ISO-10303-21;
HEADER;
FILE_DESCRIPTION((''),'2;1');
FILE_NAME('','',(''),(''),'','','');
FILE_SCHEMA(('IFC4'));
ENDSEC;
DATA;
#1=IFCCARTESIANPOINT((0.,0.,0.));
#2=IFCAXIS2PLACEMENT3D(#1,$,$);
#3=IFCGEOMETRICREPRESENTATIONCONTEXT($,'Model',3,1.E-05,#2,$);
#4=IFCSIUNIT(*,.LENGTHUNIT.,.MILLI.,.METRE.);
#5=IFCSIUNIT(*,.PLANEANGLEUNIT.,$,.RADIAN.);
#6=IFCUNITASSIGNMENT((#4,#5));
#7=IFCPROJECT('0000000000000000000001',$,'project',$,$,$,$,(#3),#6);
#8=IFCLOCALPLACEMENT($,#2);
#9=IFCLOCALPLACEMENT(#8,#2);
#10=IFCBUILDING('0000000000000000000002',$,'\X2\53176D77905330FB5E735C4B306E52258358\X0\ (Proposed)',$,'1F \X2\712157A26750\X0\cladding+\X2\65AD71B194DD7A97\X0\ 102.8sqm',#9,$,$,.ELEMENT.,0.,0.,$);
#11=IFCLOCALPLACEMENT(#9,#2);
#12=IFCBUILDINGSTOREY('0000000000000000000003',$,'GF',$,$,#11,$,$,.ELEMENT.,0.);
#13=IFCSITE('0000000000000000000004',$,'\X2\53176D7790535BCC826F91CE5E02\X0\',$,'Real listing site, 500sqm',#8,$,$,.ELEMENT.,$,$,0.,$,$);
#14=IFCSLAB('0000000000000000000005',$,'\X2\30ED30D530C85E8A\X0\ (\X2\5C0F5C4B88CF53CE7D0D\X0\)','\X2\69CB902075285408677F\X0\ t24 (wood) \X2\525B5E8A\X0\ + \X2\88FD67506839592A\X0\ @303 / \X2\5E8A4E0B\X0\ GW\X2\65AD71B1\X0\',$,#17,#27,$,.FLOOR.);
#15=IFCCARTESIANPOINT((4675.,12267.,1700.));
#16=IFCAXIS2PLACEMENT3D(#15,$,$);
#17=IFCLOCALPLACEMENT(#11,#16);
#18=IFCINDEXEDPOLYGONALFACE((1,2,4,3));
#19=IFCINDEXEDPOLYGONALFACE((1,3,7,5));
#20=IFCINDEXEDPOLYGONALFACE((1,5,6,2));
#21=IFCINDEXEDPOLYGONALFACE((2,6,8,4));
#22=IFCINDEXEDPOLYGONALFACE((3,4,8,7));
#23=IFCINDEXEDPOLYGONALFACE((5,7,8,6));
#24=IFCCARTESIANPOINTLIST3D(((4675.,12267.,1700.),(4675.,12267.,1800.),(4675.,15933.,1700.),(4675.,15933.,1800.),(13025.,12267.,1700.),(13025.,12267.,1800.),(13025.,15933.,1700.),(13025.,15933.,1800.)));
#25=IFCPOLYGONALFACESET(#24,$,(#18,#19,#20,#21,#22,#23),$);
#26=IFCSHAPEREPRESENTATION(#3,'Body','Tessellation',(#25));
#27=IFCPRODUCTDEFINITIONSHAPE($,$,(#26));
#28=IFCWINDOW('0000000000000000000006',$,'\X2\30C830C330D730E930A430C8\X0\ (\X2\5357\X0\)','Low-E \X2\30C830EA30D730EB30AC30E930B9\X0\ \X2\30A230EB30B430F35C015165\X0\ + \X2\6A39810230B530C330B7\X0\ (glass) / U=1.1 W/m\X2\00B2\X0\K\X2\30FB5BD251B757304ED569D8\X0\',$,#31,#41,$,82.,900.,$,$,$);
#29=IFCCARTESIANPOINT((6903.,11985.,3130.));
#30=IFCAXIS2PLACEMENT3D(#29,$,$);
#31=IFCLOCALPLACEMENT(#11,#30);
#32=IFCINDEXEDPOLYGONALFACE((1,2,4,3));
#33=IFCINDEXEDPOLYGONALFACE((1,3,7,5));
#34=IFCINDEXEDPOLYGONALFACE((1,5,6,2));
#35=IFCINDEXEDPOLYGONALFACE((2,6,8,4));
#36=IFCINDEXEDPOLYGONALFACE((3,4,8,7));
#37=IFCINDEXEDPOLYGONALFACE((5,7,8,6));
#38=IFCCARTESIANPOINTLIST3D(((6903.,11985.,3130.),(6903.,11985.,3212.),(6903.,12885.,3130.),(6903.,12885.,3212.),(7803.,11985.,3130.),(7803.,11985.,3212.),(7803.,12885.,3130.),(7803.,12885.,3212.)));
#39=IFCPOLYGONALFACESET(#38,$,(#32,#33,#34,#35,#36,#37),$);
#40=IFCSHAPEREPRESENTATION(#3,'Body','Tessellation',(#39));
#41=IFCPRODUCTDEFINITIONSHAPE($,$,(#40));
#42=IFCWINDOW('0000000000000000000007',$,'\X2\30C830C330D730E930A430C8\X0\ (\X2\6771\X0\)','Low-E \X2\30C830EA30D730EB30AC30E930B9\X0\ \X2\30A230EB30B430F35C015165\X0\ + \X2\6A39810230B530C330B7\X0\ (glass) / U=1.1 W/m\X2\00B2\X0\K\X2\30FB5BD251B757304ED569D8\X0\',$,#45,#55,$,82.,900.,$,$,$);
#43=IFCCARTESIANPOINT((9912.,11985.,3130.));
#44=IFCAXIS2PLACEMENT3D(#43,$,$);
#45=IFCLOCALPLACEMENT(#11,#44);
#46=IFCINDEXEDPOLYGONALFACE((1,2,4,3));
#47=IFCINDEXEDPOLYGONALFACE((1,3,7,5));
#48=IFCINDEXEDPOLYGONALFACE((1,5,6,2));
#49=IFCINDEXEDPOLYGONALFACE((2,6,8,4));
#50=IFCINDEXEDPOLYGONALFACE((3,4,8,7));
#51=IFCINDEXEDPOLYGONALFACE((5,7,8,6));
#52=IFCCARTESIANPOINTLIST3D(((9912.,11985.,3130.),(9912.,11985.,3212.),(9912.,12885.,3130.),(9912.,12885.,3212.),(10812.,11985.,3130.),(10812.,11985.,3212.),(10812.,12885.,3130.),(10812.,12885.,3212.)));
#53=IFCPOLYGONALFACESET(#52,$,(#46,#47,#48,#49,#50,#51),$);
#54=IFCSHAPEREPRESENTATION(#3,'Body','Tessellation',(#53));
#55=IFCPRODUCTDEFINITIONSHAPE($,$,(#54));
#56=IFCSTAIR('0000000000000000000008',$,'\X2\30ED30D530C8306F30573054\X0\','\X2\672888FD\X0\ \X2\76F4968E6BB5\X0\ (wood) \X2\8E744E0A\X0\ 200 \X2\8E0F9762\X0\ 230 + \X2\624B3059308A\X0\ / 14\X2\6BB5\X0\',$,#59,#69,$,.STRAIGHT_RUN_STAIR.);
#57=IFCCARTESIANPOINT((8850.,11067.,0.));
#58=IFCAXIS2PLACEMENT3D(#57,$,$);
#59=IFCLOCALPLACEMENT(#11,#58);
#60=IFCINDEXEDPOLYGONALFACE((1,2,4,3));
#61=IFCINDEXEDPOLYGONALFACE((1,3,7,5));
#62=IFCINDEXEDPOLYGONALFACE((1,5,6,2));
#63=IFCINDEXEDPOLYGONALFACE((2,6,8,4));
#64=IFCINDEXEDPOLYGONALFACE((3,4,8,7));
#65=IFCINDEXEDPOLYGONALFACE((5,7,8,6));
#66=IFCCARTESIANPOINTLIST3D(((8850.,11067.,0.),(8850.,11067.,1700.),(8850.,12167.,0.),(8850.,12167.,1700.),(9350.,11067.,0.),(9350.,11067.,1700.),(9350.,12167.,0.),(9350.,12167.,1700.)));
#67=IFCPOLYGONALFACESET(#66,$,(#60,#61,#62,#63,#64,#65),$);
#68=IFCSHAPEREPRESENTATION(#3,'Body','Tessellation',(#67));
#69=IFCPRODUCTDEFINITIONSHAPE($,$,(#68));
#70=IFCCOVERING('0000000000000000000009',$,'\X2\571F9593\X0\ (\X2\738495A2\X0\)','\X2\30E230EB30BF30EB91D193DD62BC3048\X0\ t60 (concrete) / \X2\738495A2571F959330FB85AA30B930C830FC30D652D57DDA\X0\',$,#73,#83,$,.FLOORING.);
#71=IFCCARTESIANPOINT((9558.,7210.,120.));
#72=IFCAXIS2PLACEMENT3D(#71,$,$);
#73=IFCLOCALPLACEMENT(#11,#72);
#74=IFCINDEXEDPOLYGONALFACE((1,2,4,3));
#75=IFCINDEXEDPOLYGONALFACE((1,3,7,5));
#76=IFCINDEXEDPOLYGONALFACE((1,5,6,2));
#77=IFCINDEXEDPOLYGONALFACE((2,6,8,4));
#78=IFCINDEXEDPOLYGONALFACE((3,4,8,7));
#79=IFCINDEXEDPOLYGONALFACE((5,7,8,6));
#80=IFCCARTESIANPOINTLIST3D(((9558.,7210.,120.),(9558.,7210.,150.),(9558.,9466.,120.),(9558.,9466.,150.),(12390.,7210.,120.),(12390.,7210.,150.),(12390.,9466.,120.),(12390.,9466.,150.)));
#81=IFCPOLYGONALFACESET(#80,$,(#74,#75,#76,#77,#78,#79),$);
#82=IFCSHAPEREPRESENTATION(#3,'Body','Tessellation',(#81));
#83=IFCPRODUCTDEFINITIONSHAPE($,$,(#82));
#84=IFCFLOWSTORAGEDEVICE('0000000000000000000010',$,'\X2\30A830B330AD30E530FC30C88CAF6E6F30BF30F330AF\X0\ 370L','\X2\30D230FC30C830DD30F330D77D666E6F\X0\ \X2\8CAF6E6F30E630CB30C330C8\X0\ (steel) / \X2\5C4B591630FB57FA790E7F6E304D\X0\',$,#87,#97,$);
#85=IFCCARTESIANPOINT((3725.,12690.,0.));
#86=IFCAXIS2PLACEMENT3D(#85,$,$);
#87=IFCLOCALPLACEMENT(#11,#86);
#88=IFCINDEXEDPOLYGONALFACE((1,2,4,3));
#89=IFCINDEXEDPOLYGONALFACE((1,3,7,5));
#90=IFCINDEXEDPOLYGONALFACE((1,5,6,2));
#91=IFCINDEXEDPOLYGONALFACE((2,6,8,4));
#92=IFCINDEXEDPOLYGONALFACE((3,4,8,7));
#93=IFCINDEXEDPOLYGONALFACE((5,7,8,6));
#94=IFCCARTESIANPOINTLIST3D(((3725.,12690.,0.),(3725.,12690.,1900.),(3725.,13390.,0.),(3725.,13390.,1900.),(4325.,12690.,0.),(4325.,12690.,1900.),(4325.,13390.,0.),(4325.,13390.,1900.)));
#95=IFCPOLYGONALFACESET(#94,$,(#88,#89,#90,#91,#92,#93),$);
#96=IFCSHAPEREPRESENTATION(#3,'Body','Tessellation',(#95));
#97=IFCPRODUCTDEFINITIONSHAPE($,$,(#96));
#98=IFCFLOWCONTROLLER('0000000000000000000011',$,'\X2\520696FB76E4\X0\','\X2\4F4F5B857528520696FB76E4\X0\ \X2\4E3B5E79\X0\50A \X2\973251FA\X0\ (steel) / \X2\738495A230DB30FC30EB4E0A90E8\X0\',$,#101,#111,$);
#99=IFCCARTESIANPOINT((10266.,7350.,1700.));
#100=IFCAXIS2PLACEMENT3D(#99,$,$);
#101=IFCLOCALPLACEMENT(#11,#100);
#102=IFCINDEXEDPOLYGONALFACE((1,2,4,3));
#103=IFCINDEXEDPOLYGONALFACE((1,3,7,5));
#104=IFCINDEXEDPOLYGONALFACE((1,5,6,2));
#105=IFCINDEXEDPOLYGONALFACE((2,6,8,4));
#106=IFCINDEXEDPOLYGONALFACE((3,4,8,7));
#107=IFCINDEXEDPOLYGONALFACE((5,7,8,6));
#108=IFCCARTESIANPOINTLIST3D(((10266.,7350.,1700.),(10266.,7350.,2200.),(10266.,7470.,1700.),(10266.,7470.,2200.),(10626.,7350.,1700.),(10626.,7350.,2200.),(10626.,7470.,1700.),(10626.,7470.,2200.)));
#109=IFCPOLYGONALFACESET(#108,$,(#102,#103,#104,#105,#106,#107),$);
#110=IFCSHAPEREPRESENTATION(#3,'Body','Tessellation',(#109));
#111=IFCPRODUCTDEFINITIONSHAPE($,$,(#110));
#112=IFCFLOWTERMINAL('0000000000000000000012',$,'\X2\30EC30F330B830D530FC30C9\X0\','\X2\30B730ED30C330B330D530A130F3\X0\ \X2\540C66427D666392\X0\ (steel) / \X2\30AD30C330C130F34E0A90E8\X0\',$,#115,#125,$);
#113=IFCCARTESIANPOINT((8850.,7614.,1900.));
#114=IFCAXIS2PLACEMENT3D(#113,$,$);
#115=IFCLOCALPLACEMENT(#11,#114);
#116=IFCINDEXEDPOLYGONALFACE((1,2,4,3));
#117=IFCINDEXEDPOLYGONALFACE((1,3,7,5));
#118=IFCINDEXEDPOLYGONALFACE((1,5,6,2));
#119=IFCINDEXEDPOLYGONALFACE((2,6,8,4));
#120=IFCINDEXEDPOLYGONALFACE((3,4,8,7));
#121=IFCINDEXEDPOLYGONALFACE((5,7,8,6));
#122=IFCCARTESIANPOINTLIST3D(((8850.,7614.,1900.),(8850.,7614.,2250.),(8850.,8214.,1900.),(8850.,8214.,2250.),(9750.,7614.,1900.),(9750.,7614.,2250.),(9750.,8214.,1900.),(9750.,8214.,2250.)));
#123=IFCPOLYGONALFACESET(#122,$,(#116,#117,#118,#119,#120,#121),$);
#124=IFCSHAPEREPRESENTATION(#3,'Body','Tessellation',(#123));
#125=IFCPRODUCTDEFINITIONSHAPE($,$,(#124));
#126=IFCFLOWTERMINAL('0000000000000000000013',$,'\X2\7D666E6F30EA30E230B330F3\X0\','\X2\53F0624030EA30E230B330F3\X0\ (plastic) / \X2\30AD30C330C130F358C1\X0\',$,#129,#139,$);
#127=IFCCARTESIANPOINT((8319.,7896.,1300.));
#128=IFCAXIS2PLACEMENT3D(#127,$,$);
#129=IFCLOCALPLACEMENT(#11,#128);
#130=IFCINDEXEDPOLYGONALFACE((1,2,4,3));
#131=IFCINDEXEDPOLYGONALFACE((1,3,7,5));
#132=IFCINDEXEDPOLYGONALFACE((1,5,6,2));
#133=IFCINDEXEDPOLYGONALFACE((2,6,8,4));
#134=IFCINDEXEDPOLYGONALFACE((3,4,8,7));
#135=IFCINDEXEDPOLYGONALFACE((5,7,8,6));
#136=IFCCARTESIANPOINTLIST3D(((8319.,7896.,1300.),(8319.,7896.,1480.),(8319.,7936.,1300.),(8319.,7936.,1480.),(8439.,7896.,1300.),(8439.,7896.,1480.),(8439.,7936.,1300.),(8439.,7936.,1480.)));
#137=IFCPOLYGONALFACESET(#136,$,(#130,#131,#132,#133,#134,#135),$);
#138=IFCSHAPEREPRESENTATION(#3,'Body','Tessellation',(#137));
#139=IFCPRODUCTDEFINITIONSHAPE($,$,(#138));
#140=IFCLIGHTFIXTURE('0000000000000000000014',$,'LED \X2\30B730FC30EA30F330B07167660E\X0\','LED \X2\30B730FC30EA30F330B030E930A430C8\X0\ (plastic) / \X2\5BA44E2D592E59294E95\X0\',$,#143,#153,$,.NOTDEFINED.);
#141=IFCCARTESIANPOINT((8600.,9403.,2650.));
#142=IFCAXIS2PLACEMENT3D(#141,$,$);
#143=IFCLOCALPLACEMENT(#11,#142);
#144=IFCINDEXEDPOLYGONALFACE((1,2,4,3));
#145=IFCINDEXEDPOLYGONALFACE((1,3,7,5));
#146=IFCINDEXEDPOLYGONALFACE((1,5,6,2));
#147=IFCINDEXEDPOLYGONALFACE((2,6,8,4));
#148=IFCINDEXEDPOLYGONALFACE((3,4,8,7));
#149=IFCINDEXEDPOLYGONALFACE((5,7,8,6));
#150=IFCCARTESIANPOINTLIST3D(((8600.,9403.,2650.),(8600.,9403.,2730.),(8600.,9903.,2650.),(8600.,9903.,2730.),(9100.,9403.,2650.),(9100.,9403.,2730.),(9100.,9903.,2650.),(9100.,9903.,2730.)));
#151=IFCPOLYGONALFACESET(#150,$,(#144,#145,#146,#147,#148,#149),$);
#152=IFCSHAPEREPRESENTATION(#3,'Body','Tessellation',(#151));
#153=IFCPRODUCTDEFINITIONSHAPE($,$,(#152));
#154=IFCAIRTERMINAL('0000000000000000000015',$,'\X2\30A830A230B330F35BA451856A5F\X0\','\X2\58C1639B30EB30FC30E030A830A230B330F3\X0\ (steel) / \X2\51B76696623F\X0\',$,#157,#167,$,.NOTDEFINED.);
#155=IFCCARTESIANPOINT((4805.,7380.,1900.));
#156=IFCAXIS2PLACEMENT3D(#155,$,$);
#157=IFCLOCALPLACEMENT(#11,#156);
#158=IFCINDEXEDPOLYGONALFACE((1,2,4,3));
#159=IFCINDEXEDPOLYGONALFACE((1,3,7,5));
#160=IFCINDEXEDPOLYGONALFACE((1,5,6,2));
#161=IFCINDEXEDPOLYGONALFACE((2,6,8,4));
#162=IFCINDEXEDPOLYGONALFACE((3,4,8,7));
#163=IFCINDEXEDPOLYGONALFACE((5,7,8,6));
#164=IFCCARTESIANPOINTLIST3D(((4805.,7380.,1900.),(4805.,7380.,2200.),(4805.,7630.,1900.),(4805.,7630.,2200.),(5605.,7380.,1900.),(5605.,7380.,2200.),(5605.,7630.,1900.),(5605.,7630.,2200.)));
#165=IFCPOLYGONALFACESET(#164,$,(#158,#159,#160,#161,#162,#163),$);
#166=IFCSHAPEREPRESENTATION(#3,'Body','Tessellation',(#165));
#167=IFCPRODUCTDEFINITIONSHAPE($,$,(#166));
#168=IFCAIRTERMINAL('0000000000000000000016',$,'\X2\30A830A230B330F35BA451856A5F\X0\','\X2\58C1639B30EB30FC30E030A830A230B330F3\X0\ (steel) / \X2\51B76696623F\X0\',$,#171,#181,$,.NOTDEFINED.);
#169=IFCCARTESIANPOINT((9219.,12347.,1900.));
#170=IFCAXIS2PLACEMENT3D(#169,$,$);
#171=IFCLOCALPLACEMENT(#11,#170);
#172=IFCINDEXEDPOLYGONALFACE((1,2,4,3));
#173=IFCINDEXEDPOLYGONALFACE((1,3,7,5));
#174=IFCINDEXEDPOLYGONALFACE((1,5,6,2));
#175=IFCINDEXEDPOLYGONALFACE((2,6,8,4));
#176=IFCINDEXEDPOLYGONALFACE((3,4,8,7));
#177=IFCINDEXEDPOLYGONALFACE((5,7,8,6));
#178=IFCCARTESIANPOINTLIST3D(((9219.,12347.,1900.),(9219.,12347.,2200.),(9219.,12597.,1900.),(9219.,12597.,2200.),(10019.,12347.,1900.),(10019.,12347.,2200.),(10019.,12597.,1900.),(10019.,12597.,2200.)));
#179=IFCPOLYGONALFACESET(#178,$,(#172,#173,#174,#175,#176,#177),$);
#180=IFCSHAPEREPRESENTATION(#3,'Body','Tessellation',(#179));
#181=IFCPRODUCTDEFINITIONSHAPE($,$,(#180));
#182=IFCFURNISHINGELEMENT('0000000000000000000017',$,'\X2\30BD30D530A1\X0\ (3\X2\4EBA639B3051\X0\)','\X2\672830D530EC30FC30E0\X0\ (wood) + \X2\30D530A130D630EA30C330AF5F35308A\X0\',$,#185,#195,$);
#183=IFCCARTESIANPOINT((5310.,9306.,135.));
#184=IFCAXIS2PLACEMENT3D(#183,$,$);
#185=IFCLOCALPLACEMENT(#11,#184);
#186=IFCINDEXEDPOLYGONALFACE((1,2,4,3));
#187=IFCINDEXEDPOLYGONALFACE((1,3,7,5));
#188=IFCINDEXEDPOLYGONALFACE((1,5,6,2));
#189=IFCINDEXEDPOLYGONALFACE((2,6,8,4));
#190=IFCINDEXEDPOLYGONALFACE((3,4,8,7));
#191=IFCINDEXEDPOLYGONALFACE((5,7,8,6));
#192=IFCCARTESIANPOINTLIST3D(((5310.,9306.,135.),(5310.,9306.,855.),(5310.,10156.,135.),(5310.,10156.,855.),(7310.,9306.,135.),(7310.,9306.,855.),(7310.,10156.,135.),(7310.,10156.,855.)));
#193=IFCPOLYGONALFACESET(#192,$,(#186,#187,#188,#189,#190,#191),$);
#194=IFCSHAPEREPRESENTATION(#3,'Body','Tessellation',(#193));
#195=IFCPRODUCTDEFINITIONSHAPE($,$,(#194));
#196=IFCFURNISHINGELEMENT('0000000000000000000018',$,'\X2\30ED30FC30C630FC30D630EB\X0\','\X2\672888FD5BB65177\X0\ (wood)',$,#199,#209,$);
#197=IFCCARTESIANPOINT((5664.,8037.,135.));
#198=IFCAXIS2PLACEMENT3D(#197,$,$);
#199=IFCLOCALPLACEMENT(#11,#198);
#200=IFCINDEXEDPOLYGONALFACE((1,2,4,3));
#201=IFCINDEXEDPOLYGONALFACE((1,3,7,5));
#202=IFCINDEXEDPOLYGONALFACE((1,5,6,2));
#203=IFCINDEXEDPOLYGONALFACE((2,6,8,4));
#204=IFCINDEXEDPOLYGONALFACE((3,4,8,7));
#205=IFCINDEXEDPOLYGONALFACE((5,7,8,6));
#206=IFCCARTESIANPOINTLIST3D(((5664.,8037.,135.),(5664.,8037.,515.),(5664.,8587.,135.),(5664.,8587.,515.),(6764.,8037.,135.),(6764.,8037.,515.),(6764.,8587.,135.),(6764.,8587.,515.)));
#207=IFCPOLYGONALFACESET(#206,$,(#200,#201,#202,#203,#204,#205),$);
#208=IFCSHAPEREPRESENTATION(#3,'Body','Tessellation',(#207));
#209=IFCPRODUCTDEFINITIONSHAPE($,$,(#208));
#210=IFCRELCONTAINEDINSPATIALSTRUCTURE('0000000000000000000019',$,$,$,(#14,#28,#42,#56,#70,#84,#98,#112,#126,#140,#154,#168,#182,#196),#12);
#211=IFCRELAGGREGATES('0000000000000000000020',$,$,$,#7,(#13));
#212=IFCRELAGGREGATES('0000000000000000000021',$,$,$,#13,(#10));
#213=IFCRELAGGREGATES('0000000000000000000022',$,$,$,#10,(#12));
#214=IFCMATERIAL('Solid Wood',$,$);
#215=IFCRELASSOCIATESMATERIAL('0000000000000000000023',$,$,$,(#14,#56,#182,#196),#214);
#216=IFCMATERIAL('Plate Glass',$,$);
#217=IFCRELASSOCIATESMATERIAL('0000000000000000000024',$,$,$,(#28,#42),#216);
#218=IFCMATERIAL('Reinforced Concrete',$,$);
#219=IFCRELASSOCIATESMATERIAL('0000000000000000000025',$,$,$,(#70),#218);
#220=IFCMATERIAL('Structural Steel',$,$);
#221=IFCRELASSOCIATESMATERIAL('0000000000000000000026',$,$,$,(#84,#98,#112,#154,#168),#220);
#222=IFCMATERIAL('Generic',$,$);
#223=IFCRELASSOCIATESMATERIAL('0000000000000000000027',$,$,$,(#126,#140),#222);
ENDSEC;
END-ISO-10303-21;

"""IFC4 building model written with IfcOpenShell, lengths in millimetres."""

from ifc_helpers import new_model, si_unit, frame, frame_2d, origin, place, context, project, spatial, rectangle, extrude, material, element, save


model = new_model("IFC4")

# Units and contexts
model_context = context("Model", 3, precision=1e-05, world=origin())
ifc_project = project(units=[si_unit("LENGTHUNIT", "METRE", prefix="MILLI"), si_unit("PLANEANGLEUNIT", "RADIAN")], contexts=[model_context])

# Site, building, storey
site_placement = place(None, origin())
site = spatial("IfcSite", under=ifc_project, at=site_placement, Name="北海道富良野市", ObjectType="Real listing site, 500sqm", CompositionType="ELEMENT", RefElevation=0.0)
building_placement = place(site_placement, origin())
building = spatial("IfcBuilding", under=site, at=building_placement, Name="北海道・平屋の別荘 (Proposed)", ObjectType="1F 無垢材cladding+断熱铝窗 102.8sqm", CompositionType="ELEMENT", ElevationOfRefHeight=0.0, ElevationOfTerrain=0.0)
storey_placement = place(building_placement, origin())
storey = spatial("IfcBuildingStorey", under=building, at=storey_placement, Name="GF", CompositionType="ELEMENT", Elevation=0.0)

# Shared definitions
ifc_material_1 = material(Name="Solid Wood")

# Slab
slab_placement = place(storey_placement, frame((4675.0, 12267.0, 1700.0)))
element("IfcSlab", 1, at=slab_placement, inside=storey, material=ifc_material_1, Name="ロフト床 (小屋裏収納)", Description="構造用合板 t24 (wood) 剛床 + 製材根太 @303 / 床下 GW断熱", PredefinedType="FLOOR", context=model_context, shape_type="SweptSolid", body=[
    extrude(rectangle(XDim=8350.0, YDim=3666.0, at=frame_2d((4175.0, 1833.0))), frame((4675.0, 12267.0, 1700.0)), (0.0, 0.0, 1.0), 100.0),
])

# Windows
ifc_material_2 = material(Name="Plate Glass")
window_1_placement = place(storey_placement, frame((6903.0, 11985.0, 3130.0)))
element("IfcWindow", 2, at=window_1_placement, inside=storey, material=ifc_material_2, Name="トップライト (南)", Description="Low-E トリプルガラス アルゴン封入 + 樹脂サッシ (glass) / U=1.1 W/m²K・寒冷地仕様", OverallHeight=82.0, OverallWidth=900.0, context=model_context, shape_type="SweptSolid", body=[
    extrude(rectangle(XDim=900.0, YDim=900.0, at=frame_2d((450.0, 450.0))), frame((6903.0, 11985.0, 3130.0)), (0.0, 0.0, 1.0), 82.0),
])
window_2_placement = place(storey_placement, frame((9912.0, 11985.0, 3130.0)))
element("IfcWindow", 3, at=window_2_placement, inside=storey, material=ifc_material_2, Name="トップライト (東)", Description="Low-E トリプルガラス アルゴン封入 + 樹脂サッシ (glass) / U=1.1 W/m²K・寒冷地仕様", OverallHeight=82.0, OverallWidth=900.0, context=model_context, shape_type="SweptSolid", body=[
    extrude(rectangle(XDim=900.0, YDim=900.0, at=frame_2d((450.0, 450.0))), frame((9912.0, 11985.0, 3130.0)), (0.0, 0.0, 1.0), 82.0),
])

# Stair
stair_placement = place(storey_placement, frame((8850.0, 11067.0, 0.0)))
element("IfcStair", 4, at=stair_placement, inside=storey, material=ifc_material_1, Name="ロフトはしご", Description="木製 直階段 (wood) 蹴上 200 踏面 230 + 手すり / 14段", PredefinedType="STRAIGHT_RUN_STAIR", context=model_context, shape_type="SweptSolid", body=[
    extrude(rectangle(XDim=500.0, YDim=1100.0, at=frame_2d((250.0, 550.0))), frame((8850.0, 11067.0, 0.0)), (0.0, 0.0, 1.0), 1700.0),
])

# Covering
ifc_material_3 = material(Name="Reinforced Concrete")
covering_placement = place(storey_placement, frame((9558.0, 7210.0, 120.0)))
element("IfcCovering", 5, at=covering_placement, inside=storey, material=ifc_material_3, Name="土間 (玄関)", Description="モルタル金鏝押え t60 (concrete) / 玄関土間・薪ストーブ動線", PredefinedType="FLOORING", context=model_context, shape_type="SweptSolid", body=[
    extrude(rectangle(XDim=2832.0, YDim=2256.0, at=frame_2d((1416.0, 1128.0))), frame((9558.0, 7210.0, 120.0)), (0.0, 0.0, 1.0), 30.0),
])

# Flow storage device
ifc_material_4 = material(Name="Structural Steel")
flow_storage_device_placement = place(storey_placement, frame((3725.0, 12690.0, 0.0)))
element("IfcFlowStorageDevice", 6, at=flow_storage_device_placement, inside=storey, material=ifc_material_4, Name="エコキュート貯湯タンク 370L", Description="ヒートポンプ給湯 貯湯ユニット (steel) / 屋外・基礎置き", context=model_context, shape_type="SweptSolid", body=[
    extrude(rectangle(XDim=600.0, YDim=700.0, at=frame_2d((300.0, 350.0))), frame((3725.0, 12690.0, 0.0)), (0.0, 0.0, 1.0), 1900.0),
])

# Flow controller
flow_controller_placement = place(storey_placement, frame((10266.0, 7350.0, 1700.0)))
element("IfcFlowController", 7, at=flow_controller_placement, inside=storey, material=ifc_material_4, Name="分電盤", Description="住宅用分電盤 主幹50A 露出 (steel) / 玄関ホール上部", context=model_context, shape_type="SweptSolid", body=[
    extrude(rectangle(XDim=360.0, YDim=120.0, at=frame_2d((180.0, 60.0))), frame((10266.0, 7350.0, 1700.0)), (0.0, 0.0, 1.0), 500.0),
])

# Flow terminals
flow_terminal_1_placement = place(storey_placement, frame((8850.0, 7614.0, 1900.0)))
element("IfcFlowTerminal", 8, at=flow_terminal_1_placement, inside=storey, material=ifc_material_4, Name="レンジフード", Description="シロッコファン 同時給排 (steel) / キッチン上部", context=model_context, shape_type="SweptSolid", body=[
    extrude(rectangle(XDim=900.0, YDim=600.0, at=frame_2d((450.0, 300.0))), frame((8850.0, 7614.0, 1900.0)), (0.0, 0.0, 1.0), 350.0),
])
ifc_material_5 = material(Name="Generic")
flow_terminal_2_placement = place(storey_placement, frame((8319.0, 7896.0, 1300.0)))
element("IfcFlowTerminal", 9, at=flow_terminal_2_placement, inside=storey, material=ifc_material_5, Name="給湯リモコン", Description="台所リモコン (plastic) / キッチン壁", context=model_context, shape_type="SweptSolid", body=[
    extrude(rectangle(XDim=120.0, YDim=40.0, at=frame_2d((60.0, 20.0))), frame((8319.0, 7896.0, 1300.0)), (0.0, 0.0, 1.0), 180.0),
])

# Light fixture
light_fixture_placement = place(storey_placement, frame((8600.0, 9403.0, 2650.0)))
element("IfcLightFixture", 10, at=light_fixture_placement, inside=storey, material=ifc_material_5, Name="LED シーリング照明", Description="LED シーリングライト (plastic) / 室中央天井", PredefinedType="NOTDEFINED", context=model_context, shape_type="SweptSolid", body=[
    extrude(rectangle(XDim=500.0, YDim=500.0, at=frame_2d((250.0, 250.0))), frame((8600.0, 9403.0, 2650.0)), (0.0, 0.0, 1.0), 80.0),
])

# Air terminals
air_terminal_1_placement = place(storey_placement, frame((4805.0, 7380.0, 1900.0)))
element("IfcAirTerminal", 11, at=air_terminal_1_placement, inside=storey, material=ifc_material_4, Name="エアコン室内機", Description="壁掛ルームエアコン (steel) / 冷暖房", PredefinedType="NOTDEFINED", context=model_context, shape_type="SweptSolid", body=[
    extrude(rectangle(XDim=800.0, YDim=250.0, at=frame_2d((400.0, 125.0))), frame((4805.0, 7380.0, 1900.0)), (0.0, 0.0, 1.0), 300.0),
])
air_terminal_2_placement = place(storey_placement, frame((9219.0, 12347.0, 1900.0)))
element("IfcAirTerminal", 12, at=air_terminal_2_placement, inside=storey, material=ifc_material_4, Name="エアコン室内機", Description="壁掛ルームエアコン (steel) / 冷暖房", PredefinedType="NOTDEFINED", context=model_context, shape_type="SweptSolid", body=[
    extrude(rectangle(XDim=800.0, YDim=250.0, at=frame_2d((400.0, 125.0))), frame((9219.0, 12347.0, 1900.0)), (0.0, 0.0, 1.0), 300.0),
])

# Furnishing elements
furnishing_1_placement = place(storey_placement, frame((5310.0, 9306.0, 135.0)))
element("IfcFurnishingElement", 13, at=furnishing_1_placement, inside=storey, material=ifc_material_1, Name="ソファ (3人掛け)", Description="木フレーム (wood) + ファブリック張り", context=model_context, shape_type="SweptSolid", body=[
    extrude(rectangle(XDim=2000.0, YDim=850.0, at=frame_2d((1000.0, 425.0))), frame((5310.0, 9306.0, 135.0)), (0.0, 0.0, 1.0), 720.0),
])
furnishing_2_placement = place(storey_placement, frame((5664.0, 8037.0, 135.0)))
element("IfcFurnishingElement", 14, at=furnishing_2_placement, inside=storey, material=ifc_material_1, Name="ローテーブル", Description="木製家具 (wood)", context=model_context, shape_type="SweptSolid", body=[
    extrude(rectangle(XDim=1100.0, YDim=550.0, at=frame_2d((550.0, 275.0))), frame((5664.0, 8037.0, 135.0)), (0.0, 0.0, 1.0), 380.0),
])

save(model, "model.ifc")
